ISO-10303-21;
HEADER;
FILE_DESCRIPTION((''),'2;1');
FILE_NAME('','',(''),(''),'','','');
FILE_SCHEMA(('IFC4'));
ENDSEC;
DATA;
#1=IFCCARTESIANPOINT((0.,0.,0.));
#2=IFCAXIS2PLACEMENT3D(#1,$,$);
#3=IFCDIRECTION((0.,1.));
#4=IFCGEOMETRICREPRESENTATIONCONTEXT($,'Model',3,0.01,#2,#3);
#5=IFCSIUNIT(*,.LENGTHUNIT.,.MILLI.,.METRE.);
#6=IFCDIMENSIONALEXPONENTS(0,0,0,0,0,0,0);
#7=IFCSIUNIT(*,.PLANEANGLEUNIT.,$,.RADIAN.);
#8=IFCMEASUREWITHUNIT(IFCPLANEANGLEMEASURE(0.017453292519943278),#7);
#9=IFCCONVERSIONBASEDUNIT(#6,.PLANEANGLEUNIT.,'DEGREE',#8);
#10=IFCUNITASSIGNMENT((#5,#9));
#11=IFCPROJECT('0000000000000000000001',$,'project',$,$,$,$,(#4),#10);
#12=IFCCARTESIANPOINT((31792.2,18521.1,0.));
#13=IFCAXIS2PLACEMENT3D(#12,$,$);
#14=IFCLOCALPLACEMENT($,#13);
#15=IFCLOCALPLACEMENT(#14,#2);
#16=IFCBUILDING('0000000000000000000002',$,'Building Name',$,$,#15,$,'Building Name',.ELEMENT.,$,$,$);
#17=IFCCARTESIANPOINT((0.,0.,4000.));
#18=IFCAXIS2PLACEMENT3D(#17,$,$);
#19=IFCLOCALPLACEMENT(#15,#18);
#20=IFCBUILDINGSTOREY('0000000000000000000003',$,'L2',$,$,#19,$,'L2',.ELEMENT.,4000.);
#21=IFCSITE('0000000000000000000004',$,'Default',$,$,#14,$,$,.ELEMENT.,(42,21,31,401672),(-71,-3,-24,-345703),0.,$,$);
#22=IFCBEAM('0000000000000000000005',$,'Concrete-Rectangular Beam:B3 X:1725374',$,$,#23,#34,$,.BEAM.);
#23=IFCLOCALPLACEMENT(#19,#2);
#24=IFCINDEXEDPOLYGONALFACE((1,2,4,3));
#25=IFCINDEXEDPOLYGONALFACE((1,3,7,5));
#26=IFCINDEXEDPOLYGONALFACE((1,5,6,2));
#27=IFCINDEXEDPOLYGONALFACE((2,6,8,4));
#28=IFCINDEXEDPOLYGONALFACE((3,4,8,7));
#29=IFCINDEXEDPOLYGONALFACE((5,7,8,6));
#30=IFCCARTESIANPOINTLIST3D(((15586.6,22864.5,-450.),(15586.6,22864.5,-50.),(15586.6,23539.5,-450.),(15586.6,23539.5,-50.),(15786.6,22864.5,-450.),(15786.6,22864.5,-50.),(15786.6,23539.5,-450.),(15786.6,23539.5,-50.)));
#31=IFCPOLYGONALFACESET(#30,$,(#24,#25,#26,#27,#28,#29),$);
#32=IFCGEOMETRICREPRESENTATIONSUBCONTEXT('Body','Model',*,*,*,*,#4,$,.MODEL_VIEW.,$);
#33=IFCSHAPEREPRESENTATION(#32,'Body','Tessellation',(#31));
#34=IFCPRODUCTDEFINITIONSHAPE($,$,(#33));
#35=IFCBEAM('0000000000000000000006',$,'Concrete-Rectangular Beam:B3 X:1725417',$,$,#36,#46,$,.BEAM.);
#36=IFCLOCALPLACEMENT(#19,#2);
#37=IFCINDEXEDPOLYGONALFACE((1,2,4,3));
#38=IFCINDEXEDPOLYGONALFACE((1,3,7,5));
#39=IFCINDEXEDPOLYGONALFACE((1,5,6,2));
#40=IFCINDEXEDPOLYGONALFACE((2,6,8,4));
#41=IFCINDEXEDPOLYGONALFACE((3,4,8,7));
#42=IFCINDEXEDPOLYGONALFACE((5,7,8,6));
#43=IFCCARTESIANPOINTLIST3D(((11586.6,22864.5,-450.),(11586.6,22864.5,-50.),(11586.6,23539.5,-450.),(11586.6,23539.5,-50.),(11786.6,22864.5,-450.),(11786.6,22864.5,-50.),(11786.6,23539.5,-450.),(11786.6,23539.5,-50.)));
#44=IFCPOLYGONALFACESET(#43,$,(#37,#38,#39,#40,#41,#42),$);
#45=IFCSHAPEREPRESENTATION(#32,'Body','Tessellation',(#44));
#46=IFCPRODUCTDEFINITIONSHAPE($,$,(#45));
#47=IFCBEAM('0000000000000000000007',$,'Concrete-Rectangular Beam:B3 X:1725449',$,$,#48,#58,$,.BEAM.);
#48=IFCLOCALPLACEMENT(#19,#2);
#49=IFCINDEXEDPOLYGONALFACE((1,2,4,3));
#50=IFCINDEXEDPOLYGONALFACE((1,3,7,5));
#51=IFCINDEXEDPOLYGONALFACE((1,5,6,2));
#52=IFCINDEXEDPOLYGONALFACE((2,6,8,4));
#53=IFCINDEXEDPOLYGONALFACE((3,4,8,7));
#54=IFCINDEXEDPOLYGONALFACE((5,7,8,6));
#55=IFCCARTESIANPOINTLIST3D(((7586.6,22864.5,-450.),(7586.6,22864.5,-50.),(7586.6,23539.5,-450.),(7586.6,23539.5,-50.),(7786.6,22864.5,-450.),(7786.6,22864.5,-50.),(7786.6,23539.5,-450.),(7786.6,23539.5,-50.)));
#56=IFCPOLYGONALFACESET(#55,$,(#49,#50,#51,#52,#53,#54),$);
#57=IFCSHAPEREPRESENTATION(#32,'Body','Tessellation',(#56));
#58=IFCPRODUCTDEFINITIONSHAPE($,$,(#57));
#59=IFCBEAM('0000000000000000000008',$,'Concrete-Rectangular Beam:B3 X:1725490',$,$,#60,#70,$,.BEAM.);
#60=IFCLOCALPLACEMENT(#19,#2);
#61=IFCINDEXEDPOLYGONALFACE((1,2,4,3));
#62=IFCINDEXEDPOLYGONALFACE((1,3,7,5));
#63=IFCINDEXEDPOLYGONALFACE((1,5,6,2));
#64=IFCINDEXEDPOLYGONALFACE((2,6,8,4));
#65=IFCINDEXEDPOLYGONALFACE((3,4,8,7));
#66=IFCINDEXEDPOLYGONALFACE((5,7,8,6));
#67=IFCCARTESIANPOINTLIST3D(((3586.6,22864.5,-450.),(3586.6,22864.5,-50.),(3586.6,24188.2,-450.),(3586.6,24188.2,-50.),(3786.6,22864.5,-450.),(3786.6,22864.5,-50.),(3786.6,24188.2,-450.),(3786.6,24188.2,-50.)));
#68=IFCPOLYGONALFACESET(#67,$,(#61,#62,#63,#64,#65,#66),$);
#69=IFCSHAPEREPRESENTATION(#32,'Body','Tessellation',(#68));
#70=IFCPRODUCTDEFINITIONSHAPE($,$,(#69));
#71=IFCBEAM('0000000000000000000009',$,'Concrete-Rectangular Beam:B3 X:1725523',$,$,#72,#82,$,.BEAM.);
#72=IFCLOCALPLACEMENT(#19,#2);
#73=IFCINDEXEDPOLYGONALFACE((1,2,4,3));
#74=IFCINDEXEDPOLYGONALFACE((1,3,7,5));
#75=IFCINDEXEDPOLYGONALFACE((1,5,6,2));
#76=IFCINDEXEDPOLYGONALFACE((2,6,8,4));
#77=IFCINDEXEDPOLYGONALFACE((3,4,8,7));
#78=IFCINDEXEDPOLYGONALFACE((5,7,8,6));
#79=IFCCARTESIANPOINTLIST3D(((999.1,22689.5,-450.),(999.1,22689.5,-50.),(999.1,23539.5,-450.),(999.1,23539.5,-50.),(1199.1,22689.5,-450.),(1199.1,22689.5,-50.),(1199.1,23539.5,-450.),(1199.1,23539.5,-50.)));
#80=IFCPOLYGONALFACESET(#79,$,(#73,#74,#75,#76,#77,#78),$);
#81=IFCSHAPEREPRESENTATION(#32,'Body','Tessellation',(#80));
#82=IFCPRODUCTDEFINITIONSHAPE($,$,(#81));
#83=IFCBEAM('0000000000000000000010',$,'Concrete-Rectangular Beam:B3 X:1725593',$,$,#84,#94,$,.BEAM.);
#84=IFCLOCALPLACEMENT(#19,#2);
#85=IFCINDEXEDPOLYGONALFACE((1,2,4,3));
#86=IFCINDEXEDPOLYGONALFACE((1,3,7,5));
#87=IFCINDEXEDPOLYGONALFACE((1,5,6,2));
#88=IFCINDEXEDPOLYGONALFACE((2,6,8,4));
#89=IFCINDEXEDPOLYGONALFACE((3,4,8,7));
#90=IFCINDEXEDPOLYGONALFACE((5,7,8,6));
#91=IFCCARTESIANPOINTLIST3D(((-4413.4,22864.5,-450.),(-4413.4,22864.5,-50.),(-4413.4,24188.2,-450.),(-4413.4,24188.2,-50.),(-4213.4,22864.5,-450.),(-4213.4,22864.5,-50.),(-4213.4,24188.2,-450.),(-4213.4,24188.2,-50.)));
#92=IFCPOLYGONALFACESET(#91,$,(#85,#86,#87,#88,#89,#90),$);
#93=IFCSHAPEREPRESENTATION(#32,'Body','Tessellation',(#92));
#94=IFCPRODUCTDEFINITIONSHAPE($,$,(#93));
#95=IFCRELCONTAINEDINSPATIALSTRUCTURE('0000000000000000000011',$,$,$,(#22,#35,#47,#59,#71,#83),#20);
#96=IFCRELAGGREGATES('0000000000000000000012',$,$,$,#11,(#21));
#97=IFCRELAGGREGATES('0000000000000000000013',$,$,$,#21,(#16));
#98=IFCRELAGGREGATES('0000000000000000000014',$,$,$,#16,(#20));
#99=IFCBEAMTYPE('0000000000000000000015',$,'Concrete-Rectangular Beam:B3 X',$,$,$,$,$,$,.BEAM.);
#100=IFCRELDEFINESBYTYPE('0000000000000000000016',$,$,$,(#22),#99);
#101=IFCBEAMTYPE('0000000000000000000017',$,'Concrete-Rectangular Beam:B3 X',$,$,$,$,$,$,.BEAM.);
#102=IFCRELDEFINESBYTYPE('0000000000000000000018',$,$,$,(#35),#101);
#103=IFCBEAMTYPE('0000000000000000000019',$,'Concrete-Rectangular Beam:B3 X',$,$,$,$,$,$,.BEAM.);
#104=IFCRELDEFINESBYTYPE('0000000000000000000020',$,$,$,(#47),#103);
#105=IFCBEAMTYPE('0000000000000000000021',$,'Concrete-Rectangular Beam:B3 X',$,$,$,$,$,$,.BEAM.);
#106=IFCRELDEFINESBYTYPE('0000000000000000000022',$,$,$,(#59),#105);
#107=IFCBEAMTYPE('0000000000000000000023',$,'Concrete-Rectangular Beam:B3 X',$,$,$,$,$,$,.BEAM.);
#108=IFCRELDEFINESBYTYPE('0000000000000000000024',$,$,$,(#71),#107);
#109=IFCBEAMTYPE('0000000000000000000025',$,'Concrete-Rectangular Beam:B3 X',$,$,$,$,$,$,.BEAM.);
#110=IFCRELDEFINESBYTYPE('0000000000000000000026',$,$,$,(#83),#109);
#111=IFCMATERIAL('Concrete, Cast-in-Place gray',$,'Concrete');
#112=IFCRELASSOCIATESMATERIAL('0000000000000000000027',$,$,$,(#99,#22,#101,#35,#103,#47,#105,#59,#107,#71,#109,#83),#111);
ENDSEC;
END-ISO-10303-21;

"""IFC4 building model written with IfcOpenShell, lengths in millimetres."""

from ifc_helpers import new_model, entity, si_unit, converted_unit, direction, frame, origin, place, context, subcontext, project, spatial, indexed_curve, outline, extrude, source, transform, mapped, material, type_object, type_shapes, element, save


model = new_model("IFC4")

# Units and contexts
model_context = context("Model", 3, precision=0.01, world=origin(), true_north=direction((0.0, 1.0)))
body_context = subcontext(model_context, "Body", "Model", "MODEL_VIEW")
ifc_project = project(units=[si_unit("LENGTHUNIT", "METRE", prefix="MILLI"), converted_unit("PLANEANGLEUNIT", "DEGREE", entity("IfcPlaneAngleMeasure", 0.017453292519943278), si_unit("PLANEANGLEUNIT", "RADIAN"), dimensions=[0, 0, 0, 0, 0, 0, 0])], contexts=[model_context])

# Site, building, storey
site_placement = place(None, frame((31792.2, 18521.1, 0.0)))
site = spatial("IfcSite", under=ifc_project, at=site_placement, Name="Default", CompositionType="ELEMENT", RefLatitude=(42, 21, 31, 401672), RefLongitude=(-71, -3, -24, -345703), RefElevation=0.0)
building_placement = place(site_placement, origin())
building = spatial("IfcBuilding", under=site, at=building_placement, Name="Building Name", LongName="Building Name", CompositionType="ELEMENT")
storey_placement = place(building_placement, frame((0.0, 0.0, 4000.0)))
storey = spatial("IfcBuildingStorey", under=building, at=storey_placement, Name="L2", LongName="L2", CompositionType="ELEMENT", Elevation=4000.0)

# Beams
ifc_material = material(Name="Concrete, Cast-in-Place gray", Category="Concrete")
beam_type_1 = type_object("IfcBeamType", Name="Concrete-Rectangular Beam:B3 X", PredefinedType="BEAM", material=ifc_material)
shared_shape_1 = source(origin(), body_context, "Body", "SweptSolid", [
    extrude(outline(indexed_curve([(-100.0, -200.0), (100.0, -200.0), (100.0, 200.0), (-100.0, 200.0), (-100.0, -200.0)], self_intersect=False)), frame((15686.6, 23539.5, 3750.0), z_axis=(0.0, -1.0, 0.0), x_axis=(-1.0, 0.0, 0.0)), (0.0, 0.0, 1.0), 675.0),
])
type_shapes(beam_type_1, [shared_shape_1])
beam_1_placement = place(storey_placement, frame((0.0, 0.0, -4000.0)))
element("IfcBeam", 1, at=beam_1_placement, inside=storey, type_object=beam_type_1, material=ifc_material, Name="Concrete-Rectangular Beam:B3 X:1725374", PredefinedType="BEAM", context=body_context, shape_type="MappedRepresentation", body=[
    mapped(shared_shape_1, transform((0.0, 0.0, 0.0), scale=1.0)),
])
beam_type_2 = type_object("IfcBeamType", Name="Concrete-Rectangular Beam:B3 X", PredefinedType="BEAM", material=ifc_material)
shared_shape_2 = source(origin(), body_context, "Body", "SweptSolid", [
    extrude(outline(indexed_curve([(-100.0, -200.0), (100.0, -200.0), (100.0, 200.0), (-100.0, 200.0), (-100.0, -200.0)], self_intersect=False)), frame((11686.6, 23539.5, 3750.0), z_axis=(0.0, -1.0, 0.0), x_axis=(-1.0, 0.0, 0.0)), (0.0, 0.0, 1.0), 675.0),
])
type_shapes(beam_type_2, [shared_shape_2])
beam_2_placement = place(storey_placement, frame((0.0, 0.0, -4000.0)))
element("IfcBeam", 2, at=beam_2_placement, inside=storey, type_object=beam_type_2, material=ifc_material, Name="Concrete-Rectangular Beam:B3 X:1725417", PredefinedType="BEAM", context=body_context, shape_type="MappedRepresentation", body=[
    mapped(shared_shape_2, transform((0.0, 0.0, 0.0), scale=1.0)),
])
beam_type_3 = type_object("IfcBeamType", Name="Concrete-Rectangular Beam:B3 X", PredefinedType="BEAM", material=ifc_material)
shared_shape_3 = source(origin(), body_context, "Body", "SweptSolid", [
    extrude(outline(indexed_curve([(-100.0, -200.0), (100.0, -200.0), (100.0, 200.0), (-100.0, 200.0), (-100.0, -200.0)], self_intersect=False)), frame((7686.6, 23539.5, 3750.0), z_axis=(0.0, -1.0, 0.0), x_axis=(-1.0, 0.0, 0.0)), (0.0, 0.0, 1.0), 675.0),
])
type_shapes(beam_type_3, [shared_shape_3])
beam_3_placement = place(storey_placement, frame((0.0, 0.0, -4000.0)))
element("IfcBeam", 3, at=beam_3_placement, inside=storey, type_object=beam_type_3, material=ifc_material, Name="Concrete-Rectangular Beam:B3 X:1725449", PredefinedType="BEAM", context=body_context, shape_type="MappedRepresentation", body=[
    mapped(shared_shape_3, transform((0.0, 0.0, 0.0), scale=1.0)),
])
beam_type_4 = type_object("IfcBeamType", Name="Concrete-Rectangular Beam:B3 X", PredefinedType="BEAM", material=ifc_material)
shared_shape_4 = source(origin(), body_context, "Body", "SweptSolid", [
    extrude(outline(indexed_curve([(-100.0, -200.0), (100.0, -200.0), (100.0, 200.0), (-100.0, 200.0), (-100.0, -200.0)], self_intersect=False)), frame((3686.6, 22864.5, 3750.0), z_axis=(0.0, 1.0, 0.0), x_axis=(-1.0, 0.0, 0.0)), (0.0, 0.0, 1.0), 1323.7),
])
type_shapes(beam_type_4, [shared_shape_4])
beam_4_placement = place(storey_placement, frame((0.0, 0.0, -4000.0)))
element("IfcBeam", 4, at=beam_4_placement, inside=storey, type_object=beam_type_4, material=ifc_material, Name="Concrete-Rectangular Beam:B3 X:1725490", PredefinedType="BEAM", context=body_context, shape_type="MappedRepresentation", body=[
    mapped(shared_shape_4, transform((0.0, 0.0, 0.0), scale=1.0)),
])
beam_type_5 = type_object("IfcBeamType", Name="Concrete-Rectangular Beam:B3 X", PredefinedType="BEAM", material=ifc_material)
shared_shape_5 = source(origin(), body_context, "Body", "SweptSolid", [
    extrude(outline(indexed_curve([(-100.0, -200.0), (100.0, -200.0), (100.0, 200.0), (-100.0, 200.0), (-100.0, -200.0)], self_intersect=False)), frame((1099.1, 23539.5, 3750.0), z_axis=(0.0, -1.0, 0.0), x_axis=(-1.0, 0.0, 0.0)), (0.0, 0.0, 1.0), 850.0),
])
type_shapes(beam_type_5, [shared_shape_5])
beam_5_placement = place(storey_placement, frame((0.0, 0.0, -4000.0)))
element("IfcBeam", 5, at=beam_5_placement, inside=storey, type_object=beam_type_5, material=ifc_material, Name="Concrete-Rectangular Beam:B3 X:1725523", PredefinedType="BEAM", context=body_context, shape_type="MappedRepresentation", body=[
    mapped(shared_shape_5, transform((0.0, 0.0, 0.0), scale=1.0)),
])
beam_type_6 = type_object("IfcBeamType", Name="Concrete-Rectangular Beam:B3 X", PredefinedType="BEAM", material=ifc_material)
shared_shape_6 = source(origin(), body_context, "Body", "SweptSolid", [
    extrude(outline(indexed_curve([(-100.0, -200.0), (100.0, -200.0), (100.0, 200.0), (-100.0, 200.0), (-100.0, -200.0)], self_intersect=False)), frame((-4313.4, 22864.5, 3750.0), z_axis=(0.0, 1.0, 0.0), x_axis=(-1.0, 0.0, 0.0)), (0.0, 0.0, 1.0), 1323.7),
])
type_shapes(beam_type_6, [shared_shape_6])
beam_6_placement = place(storey_placement, frame((0.0, 0.0, -4000.0)))
element("IfcBeam", 6, at=beam_6_placement, inside=storey, type_object=beam_type_6, material=ifc_material, Name="Concrete-Rectangular Beam:B3 X:1725593", PredefinedType="BEAM", context=body_context, shape_type="MappedRepresentation", body=[
    mapped(shared_shape_6, transform((0.0, 0.0, 0.0), scale=1.0)),
])

save(model, "model.ifc")
